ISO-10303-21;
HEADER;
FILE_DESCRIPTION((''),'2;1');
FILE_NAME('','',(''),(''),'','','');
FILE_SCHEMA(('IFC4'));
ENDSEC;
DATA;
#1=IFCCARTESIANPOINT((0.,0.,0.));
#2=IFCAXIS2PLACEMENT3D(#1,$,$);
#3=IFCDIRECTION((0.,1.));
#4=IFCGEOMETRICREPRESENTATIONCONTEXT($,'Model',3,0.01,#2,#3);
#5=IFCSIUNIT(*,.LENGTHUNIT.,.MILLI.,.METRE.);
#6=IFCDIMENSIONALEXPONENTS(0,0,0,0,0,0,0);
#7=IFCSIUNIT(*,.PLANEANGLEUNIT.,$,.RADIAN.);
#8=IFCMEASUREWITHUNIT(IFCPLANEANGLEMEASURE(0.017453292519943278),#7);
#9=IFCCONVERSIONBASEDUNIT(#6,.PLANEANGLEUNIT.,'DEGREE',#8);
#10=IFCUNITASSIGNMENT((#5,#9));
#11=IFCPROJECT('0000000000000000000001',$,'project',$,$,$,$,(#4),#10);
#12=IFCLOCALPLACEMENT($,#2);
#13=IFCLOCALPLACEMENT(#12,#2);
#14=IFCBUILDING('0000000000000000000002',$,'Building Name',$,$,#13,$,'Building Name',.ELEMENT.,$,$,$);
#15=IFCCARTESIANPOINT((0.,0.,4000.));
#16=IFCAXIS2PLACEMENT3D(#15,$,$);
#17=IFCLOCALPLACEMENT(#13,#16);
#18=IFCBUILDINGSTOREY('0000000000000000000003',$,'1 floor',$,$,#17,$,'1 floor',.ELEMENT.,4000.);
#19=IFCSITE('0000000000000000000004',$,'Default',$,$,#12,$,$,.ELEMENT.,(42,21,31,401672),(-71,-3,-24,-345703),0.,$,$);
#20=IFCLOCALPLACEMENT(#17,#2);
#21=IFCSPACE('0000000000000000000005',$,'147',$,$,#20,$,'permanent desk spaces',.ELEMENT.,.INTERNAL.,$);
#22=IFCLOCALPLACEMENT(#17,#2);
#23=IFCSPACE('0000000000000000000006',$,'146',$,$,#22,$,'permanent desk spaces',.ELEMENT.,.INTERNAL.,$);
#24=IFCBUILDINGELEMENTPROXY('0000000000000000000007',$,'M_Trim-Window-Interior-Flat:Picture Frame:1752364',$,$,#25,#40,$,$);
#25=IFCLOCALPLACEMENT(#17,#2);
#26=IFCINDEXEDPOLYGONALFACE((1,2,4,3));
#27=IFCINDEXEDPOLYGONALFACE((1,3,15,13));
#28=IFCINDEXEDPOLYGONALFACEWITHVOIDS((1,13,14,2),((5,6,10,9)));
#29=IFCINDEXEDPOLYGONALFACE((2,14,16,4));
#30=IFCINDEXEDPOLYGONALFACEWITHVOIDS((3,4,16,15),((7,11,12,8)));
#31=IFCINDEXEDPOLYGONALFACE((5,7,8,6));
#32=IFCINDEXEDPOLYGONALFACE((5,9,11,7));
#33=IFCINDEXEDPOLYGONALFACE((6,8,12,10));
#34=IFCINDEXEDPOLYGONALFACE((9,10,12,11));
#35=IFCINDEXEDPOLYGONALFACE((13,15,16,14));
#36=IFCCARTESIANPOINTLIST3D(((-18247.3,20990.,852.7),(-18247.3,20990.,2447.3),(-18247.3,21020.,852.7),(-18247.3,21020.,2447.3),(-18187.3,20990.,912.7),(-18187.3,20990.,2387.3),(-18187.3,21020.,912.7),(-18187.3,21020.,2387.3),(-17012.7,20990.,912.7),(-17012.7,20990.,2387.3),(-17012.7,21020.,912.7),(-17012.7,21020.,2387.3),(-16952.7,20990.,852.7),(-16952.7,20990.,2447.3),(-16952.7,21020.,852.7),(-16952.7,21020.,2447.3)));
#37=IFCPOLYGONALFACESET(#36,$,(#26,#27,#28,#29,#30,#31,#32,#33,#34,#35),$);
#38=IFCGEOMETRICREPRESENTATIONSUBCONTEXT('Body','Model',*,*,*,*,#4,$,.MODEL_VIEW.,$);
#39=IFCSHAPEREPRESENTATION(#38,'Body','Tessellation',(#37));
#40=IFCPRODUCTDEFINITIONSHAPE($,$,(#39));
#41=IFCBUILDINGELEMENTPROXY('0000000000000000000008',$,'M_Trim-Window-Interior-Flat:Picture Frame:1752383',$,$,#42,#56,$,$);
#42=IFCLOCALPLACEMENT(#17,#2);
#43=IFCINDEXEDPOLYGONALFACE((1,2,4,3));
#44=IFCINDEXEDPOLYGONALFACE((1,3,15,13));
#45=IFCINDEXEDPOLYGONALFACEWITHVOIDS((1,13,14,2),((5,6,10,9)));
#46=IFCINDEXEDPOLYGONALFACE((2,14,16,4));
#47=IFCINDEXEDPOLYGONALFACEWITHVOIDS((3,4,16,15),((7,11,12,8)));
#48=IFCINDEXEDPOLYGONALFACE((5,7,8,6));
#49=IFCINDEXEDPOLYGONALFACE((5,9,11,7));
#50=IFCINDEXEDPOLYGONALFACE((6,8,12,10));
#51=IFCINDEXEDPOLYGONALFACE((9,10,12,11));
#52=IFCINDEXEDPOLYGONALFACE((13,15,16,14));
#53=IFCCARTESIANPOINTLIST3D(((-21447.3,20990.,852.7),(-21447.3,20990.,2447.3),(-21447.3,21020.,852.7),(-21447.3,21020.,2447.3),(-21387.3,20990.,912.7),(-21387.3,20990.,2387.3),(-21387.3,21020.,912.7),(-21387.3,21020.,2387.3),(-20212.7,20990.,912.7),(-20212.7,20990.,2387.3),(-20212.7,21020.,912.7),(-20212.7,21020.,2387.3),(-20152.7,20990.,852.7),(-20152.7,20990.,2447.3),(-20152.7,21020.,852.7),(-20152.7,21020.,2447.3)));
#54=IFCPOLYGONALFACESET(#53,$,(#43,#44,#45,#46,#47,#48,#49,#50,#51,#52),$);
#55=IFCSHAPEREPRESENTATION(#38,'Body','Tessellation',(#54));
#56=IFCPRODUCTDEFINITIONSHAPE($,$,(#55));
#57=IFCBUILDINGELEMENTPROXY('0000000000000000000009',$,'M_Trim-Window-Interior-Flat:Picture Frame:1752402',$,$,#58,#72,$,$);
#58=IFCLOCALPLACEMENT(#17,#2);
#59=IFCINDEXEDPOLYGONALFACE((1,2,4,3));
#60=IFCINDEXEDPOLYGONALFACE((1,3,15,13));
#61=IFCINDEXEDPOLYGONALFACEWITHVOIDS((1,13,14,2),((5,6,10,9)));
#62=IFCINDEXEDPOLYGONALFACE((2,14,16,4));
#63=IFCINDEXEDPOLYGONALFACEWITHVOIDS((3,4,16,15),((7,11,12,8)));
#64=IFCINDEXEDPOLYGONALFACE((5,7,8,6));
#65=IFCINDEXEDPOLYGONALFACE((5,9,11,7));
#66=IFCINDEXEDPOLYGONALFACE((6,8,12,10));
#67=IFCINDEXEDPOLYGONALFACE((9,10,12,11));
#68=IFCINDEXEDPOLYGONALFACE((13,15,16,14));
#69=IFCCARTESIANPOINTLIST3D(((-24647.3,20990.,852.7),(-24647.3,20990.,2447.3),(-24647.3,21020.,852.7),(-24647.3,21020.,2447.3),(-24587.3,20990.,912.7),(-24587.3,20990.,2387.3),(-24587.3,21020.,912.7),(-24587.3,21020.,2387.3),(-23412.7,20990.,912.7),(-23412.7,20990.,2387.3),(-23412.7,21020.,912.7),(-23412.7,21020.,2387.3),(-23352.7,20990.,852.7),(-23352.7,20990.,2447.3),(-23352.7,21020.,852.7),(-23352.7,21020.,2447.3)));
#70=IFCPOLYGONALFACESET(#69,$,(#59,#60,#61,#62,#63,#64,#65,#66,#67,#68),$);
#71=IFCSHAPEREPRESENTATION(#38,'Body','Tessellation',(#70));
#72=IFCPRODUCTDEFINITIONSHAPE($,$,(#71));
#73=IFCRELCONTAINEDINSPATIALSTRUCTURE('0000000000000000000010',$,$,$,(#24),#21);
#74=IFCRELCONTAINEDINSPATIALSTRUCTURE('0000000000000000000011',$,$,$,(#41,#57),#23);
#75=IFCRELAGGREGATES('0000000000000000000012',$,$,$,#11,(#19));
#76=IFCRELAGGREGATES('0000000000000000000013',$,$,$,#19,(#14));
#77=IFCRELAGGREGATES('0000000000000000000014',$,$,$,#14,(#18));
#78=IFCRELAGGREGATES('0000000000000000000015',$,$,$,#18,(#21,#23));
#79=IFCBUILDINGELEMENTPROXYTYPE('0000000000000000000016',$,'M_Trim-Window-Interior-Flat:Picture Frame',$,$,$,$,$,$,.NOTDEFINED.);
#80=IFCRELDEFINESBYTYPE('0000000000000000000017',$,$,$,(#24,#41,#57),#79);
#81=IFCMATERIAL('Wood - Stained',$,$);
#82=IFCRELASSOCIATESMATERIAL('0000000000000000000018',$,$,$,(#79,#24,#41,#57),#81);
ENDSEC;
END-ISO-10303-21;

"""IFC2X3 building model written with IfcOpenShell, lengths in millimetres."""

from ifc_helpers import new_model, entity, si_unit, converted_unit, direction, frame, origin, place, context, subcontext, project, spatial, polyline, outline, extrude, source, transform, mapped, material, type_object, type_shapes, element, save


model = new_model("IFC2X3")

# Units and contexts
model_context = context("Model", 3, precision=0.01, world=origin(), true_north=direction((0.0, 1.0)))
body_context = subcontext(model_context, "Body", "Model", "MODEL_VIEW")
ifc_project = project(units=[si_unit("LENGTHUNIT", "METRE", prefix="MILLI"), converted_unit("PLANEANGLEUNIT", "DEGREE", entity("IfcPlaneAngleMeasure", 0.017453292519943278), si_unit("PLANEANGLEUNIT", "RADIAN"), dimensions=[0, 0, 0, 0, 0, 0, 0])], contexts=[model_context])

# Site, building, storey
site_placement = place(None, origin())
site = spatial("IfcSite", under=ifc_project, at=site_placement, Name="Default", CompositionType="ELEMENT", RefLatitude=(42, 21, 31, 401672), RefLongitude=(-71, -3, -24, -345703), RefElevation=0.0)
building_placement = place(site_placement, origin())
building = spatial("IfcBuilding", under=site, at=building_placement, Name="Building Name", LongName="Building Name", CompositionType="ELEMENT")
storey_placement = place(building_placement, frame((0.0, 0.0, 4000.0)))
storey = spatial("IfcBuildingStorey", under=building, at=storey_placement, Name="1 floor", LongName="1 floor", CompositionType="ELEMENT", Elevation=4000.0)

# Shared definitions
ifc_material_1 = material(Name="Wood - Stained")

# Shared definitions
space_1_placement = place(storey_placement, origin())
space_1 = spatial("IfcSpace", under=storey, at=space_1_placement, Name="147", LongName="permanent desk spaces", CompositionType="ELEMENT", InteriorOrExteriorSpace="INTERNAL")

# Building element proxy
building_element_proxy_type_1 = type_object("IfcBuildingElementProxyType", Name="M_Trim-Window-Interior-Flat:Picture Frame", PredefinedType="NOTDEFINED", material=ifc_material_1)
shared_shape_1 = source(origin(), body_context, "Body", "SweptSolid", [
    extrude(outline(polyline([(-647.3, -797.3), (647.3, -797.3), (647.3, 797.3), (-647.3, 797.3), (-647.3, -797.3)]), holes=[polyline([(-587.3, -737.3), (-587.3, 737.3), (587.3, 737.3), (587.3, -737.3), (-587.3, -737.3)])]), frame((0.0, -750.0, 0.0), z_axis=(0.0, 0.0, 1.0), x_axis=(-1.0, 0.0, 0.0)), (0.0, 0.0, 1.0), 30.0),
])
type_shapes(building_element_proxy_type_1, [shared_shape_1])
proxy_placement = place(space_1_placement, frame((-17600.0, 21020.0, 2400.0), z_axis=(0.0, -1.0, 0.0), x_axis=(1.0, 0.0, 0.0)))
element("IfcBuildingElementProxy", 1, at=proxy_placement, inside=space_1, type_object=building_element_proxy_type_1, material=ifc_material_1, Name="M_Trim-Window-Interior-Flat:Picture Frame:1752364", context=body_context, shape_type="MappedRepresentation", body=[
    mapped(shared_shape_1, transform((0.0, 0.0, 0.0), scale=1.0)),
])

# Shared definitions
space_2_placement = place(storey_placement, origin())
space_2 = spatial("IfcSpace", under=storey, at=space_2_placement, Name="146", LongName="permanent desk spaces", CompositionType="ELEMENT", InteriorOrExteriorSpace="INTERNAL")

# Building element proxies
for number, where, z_axis, x_axis, name in (
    (2, (-20800.0, 21020.0, 2400.0), (0.0, -1.0, 0.0), (1.0, 0.0, 0.0), "M_Trim-Window-Interior-Flat:Picture Frame:1752383"),
    (3, (-24000.0, 21020.0, 2400.0), (0.0, -1.0, 0.0), (1.0, 0.0, 0.0), "M_Trim-Window-Interior-Flat:Picture Frame:1752402"),
):
    element("IfcBuildingElementProxy", number, at=place(space_2_placement, frame(where, z_axis=z_axis, x_axis=x_axis)), inside=space_2, type_object=building_element_proxy_type_1, material=ifc_material_1, Name=name, context=body_context, shape_type="MappedRepresentation", body=[
        mapped(shared_shape_1, transform((0.0, 0.0, 0.0), scale=1.0)),
    ])

save(model, "model.ifc")
